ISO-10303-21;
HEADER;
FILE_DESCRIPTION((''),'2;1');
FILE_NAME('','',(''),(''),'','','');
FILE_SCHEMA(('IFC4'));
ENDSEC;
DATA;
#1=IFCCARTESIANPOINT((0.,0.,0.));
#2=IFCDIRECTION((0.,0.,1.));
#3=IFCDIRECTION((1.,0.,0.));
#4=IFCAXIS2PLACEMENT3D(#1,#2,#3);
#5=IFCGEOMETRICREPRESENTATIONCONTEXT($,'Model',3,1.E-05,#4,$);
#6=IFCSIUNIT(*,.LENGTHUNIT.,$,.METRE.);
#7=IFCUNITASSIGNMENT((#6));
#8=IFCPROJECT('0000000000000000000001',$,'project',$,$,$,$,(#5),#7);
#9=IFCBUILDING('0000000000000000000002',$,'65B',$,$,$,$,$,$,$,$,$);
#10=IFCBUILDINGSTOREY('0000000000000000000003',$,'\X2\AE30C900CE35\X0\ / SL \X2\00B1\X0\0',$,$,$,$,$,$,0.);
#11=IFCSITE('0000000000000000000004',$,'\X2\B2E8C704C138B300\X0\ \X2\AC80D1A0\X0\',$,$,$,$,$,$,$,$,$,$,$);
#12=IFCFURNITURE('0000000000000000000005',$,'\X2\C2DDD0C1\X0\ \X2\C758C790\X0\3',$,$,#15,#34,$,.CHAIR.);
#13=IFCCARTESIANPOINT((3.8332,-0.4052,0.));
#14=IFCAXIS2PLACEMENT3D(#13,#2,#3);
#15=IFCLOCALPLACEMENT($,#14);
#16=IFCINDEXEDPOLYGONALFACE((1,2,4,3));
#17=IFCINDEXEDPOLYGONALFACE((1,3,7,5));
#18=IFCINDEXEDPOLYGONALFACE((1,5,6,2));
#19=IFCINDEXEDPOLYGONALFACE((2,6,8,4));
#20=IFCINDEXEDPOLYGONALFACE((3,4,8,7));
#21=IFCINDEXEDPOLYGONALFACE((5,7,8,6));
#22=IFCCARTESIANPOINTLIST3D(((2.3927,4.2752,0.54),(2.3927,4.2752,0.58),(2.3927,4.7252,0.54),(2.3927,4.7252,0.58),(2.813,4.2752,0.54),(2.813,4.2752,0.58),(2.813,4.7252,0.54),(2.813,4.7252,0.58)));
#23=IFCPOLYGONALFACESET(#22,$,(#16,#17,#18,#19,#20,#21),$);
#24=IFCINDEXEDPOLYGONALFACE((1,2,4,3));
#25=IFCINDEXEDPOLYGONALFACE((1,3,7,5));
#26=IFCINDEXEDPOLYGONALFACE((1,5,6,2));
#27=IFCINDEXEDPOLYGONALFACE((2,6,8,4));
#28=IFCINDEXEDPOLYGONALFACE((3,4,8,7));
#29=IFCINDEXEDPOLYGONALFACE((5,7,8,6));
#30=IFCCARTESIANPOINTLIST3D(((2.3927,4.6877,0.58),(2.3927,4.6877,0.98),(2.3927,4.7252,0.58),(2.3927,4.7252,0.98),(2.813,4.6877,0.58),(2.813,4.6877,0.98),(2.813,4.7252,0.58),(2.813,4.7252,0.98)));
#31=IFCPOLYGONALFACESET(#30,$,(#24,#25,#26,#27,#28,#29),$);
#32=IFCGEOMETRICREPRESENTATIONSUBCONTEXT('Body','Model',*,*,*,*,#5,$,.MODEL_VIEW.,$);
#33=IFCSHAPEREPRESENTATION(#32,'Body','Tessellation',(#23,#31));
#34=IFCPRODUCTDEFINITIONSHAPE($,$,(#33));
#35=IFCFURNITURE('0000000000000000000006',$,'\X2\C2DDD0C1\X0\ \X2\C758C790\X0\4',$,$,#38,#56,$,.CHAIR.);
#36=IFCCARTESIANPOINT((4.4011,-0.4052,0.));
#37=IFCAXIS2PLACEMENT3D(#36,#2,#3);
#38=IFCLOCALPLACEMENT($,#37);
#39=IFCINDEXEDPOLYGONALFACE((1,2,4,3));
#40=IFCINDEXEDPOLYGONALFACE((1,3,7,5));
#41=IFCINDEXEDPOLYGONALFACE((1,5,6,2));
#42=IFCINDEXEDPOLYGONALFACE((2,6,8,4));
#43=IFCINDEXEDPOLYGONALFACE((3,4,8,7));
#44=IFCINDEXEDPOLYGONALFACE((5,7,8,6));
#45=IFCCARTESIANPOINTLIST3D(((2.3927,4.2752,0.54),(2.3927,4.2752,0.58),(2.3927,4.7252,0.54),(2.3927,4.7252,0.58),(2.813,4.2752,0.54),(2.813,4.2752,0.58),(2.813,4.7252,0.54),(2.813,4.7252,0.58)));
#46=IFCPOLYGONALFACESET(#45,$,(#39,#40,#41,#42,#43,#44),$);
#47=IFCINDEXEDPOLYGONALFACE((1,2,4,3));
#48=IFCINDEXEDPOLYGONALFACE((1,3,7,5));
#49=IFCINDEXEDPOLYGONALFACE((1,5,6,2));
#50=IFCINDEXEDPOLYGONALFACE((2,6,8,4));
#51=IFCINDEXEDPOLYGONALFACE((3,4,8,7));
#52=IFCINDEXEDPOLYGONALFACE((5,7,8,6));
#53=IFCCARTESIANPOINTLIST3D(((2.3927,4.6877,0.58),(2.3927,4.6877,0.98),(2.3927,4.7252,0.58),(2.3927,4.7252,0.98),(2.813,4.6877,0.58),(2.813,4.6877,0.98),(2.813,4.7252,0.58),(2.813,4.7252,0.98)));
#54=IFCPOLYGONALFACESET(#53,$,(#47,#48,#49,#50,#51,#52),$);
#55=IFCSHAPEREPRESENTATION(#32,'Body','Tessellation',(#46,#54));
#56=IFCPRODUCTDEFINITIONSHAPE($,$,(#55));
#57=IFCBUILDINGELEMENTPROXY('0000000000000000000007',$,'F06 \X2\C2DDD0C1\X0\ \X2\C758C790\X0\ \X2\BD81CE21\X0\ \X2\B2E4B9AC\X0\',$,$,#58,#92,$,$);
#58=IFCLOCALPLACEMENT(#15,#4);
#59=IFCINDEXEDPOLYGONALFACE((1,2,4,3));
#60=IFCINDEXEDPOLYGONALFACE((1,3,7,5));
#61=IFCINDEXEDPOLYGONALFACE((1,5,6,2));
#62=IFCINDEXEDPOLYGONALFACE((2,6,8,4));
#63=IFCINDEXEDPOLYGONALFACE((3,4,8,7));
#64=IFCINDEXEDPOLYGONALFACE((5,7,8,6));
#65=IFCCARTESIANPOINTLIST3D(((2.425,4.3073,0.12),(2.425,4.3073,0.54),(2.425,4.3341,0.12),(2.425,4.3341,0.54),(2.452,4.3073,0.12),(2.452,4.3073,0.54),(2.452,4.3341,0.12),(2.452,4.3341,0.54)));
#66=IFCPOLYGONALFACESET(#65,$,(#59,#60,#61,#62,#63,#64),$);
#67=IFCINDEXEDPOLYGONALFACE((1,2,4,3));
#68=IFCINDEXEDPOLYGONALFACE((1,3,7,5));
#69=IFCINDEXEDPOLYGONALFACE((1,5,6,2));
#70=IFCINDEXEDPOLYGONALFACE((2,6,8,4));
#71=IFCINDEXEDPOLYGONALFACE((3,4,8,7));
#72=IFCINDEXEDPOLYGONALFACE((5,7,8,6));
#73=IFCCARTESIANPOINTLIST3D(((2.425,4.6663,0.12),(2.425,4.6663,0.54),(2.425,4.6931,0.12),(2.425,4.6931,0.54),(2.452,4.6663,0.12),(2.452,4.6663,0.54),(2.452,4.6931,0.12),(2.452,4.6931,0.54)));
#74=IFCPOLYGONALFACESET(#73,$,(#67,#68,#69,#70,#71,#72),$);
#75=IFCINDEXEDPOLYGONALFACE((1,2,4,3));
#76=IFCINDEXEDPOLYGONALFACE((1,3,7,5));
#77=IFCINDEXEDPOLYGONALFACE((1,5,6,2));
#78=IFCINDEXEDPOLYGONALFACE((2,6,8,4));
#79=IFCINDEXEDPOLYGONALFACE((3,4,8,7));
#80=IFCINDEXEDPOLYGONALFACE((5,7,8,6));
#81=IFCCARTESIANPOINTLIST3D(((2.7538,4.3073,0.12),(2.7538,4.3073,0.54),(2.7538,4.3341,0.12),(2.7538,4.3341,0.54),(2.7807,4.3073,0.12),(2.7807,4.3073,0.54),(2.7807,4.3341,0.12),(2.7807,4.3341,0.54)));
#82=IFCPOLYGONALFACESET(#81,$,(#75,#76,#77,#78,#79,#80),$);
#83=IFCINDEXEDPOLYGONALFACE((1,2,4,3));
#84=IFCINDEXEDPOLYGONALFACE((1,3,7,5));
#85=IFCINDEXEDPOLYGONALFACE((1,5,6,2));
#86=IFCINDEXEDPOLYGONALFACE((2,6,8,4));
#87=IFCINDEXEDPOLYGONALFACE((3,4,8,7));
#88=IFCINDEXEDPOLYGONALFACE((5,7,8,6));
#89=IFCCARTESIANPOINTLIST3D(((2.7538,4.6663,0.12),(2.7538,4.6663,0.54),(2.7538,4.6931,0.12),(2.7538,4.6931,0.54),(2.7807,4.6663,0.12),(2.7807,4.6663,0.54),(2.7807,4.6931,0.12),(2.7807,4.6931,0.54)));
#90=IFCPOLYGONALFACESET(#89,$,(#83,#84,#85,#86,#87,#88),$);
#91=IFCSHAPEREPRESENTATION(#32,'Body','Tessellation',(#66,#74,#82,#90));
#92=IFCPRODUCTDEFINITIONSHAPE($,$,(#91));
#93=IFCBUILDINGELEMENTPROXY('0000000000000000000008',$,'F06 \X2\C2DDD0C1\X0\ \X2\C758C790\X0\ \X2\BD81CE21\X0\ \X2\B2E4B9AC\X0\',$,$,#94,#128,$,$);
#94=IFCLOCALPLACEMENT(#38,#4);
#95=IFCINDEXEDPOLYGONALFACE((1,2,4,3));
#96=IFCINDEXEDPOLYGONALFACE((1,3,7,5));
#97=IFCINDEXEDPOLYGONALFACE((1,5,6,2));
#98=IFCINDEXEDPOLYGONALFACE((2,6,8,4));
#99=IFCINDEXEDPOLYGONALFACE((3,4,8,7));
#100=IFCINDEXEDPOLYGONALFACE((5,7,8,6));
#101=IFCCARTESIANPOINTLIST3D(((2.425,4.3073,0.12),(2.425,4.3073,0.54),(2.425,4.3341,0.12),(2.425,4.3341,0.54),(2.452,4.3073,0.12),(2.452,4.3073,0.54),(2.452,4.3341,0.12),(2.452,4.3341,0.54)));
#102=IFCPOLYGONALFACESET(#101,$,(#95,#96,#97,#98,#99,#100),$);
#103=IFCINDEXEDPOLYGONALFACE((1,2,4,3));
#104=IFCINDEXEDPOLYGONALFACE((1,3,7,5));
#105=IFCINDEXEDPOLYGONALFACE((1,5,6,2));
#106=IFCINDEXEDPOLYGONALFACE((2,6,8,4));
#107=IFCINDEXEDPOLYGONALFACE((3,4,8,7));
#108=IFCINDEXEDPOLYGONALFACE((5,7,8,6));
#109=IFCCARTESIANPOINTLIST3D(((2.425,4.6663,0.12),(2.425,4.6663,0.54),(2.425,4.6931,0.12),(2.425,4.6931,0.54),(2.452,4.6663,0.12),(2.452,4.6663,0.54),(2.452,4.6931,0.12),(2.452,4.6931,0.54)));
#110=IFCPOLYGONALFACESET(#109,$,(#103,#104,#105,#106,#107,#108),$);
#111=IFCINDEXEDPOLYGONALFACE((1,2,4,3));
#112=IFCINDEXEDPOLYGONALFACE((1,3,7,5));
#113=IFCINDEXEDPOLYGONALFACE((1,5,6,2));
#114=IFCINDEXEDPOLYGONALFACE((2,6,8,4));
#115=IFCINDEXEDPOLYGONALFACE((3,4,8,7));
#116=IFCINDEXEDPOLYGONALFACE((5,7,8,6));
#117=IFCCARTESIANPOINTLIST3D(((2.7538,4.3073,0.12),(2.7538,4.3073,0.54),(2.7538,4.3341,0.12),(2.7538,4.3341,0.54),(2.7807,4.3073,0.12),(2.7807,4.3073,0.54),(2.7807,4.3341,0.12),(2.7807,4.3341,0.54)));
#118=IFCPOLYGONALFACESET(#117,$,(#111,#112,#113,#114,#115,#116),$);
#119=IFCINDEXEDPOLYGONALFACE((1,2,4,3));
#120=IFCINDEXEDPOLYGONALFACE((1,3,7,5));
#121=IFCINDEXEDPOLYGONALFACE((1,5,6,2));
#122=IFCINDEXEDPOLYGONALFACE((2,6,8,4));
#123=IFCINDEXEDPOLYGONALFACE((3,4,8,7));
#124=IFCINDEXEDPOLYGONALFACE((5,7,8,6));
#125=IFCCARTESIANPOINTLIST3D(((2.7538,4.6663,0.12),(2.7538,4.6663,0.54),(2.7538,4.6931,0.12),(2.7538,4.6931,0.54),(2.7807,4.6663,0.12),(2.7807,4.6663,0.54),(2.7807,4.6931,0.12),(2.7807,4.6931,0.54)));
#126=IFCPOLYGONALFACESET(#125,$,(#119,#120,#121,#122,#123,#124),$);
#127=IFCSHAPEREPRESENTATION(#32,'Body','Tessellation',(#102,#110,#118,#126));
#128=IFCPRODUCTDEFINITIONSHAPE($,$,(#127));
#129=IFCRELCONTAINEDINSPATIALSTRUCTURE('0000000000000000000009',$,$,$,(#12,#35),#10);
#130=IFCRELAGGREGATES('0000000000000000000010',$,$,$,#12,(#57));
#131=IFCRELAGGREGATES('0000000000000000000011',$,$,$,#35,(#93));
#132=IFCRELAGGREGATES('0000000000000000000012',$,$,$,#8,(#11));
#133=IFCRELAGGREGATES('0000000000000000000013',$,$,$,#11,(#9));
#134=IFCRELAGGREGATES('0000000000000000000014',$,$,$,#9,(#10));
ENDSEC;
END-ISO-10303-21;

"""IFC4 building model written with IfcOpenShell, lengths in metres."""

from ifc_helpers import new_model, si_unit, frame, origin_with_axes, place, context, subcontext, project, spatial, polyline, outline, extrude, element, aggregate, save


model = new_model("IFC4")

# Units and contexts
model_context = context("Model", 3, precision=1e-05, world=origin_with_axes())
body_context = subcontext(model_context, "Body", "Model", "MODEL_VIEW")
ifc_project = project(units=[si_unit("LENGTHUNIT", "METRE")], contexts=[model_context])

# Site, building, storey
site = spatial("IfcSite", under=ifc_project, Name="단위세대 검토")
building = spatial("IfcBuilding", under=site, Name="65B")
storey = spatial("IfcBuildingStorey", under=building, Name="기준층 / SL ±0", Elevation=0.0)

# Furniture
furniture_1_placement = place(None, frame((3.8332, -0.4052, 0.0), z_axis=(0.0, 0.0, 1.0), x_axis=(1.0, 0.0, 0.0)))
furniture_1 = element("IfcFurniture", 1, at=furniture_1_placement, inside=storey, Name="식탁 의자3", PredefinedType="CHAIR", context=body_context, shape_type="SweptSolid", body=[
    extrude(outline(polyline([(2.813, 4.2752), (2.813, 4.7252), (2.3927, 4.7252), (2.3927, 4.2752), (2.813, 4.2752)])), frame((0.0, 0.0, 0.54)), (0.0, 0.0, 1.0), 0.04),
    extrude(outline(polyline([(2.813, 4.6877), (2.813, 4.7252), (2.3927, 4.7252), (2.3927, 4.6877), (2.813, 4.6877)])), frame((0.0, 0.0, 0.58)), (0.0, 0.0, 1.0), 0.4),
])
furniture_2_placement = place(None, frame((4.4011, -0.4052, 0.0), z_axis=(0.0, 0.0, 1.0), x_axis=(1.0, 0.0, 0.0)))
furniture_2 = element("IfcFurniture", 2, at=furniture_2_placement, inside=storey, Name="식탁 의자4", PredefinedType="CHAIR", context=body_context, shape_type="SweptSolid", body=[
    extrude(outline(polyline([(2.813, 4.2752), (2.813, 4.7252), (2.3927, 4.7252), (2.3927, 4.2752), (2.813, 4.2752)])), frame((0.0, 0.0, 0.54)), (0.0, 0.0, 1.0), 0.04),
    extrude(outline(polyline([(2.813, 4.6877), (2.813, 4.7252), (2.3927, 4.7252), (2.3927, 4.6877), (2.813, 4.6877)])), frame((0.0, 0.0, 0.58)), (0.0, 0.0, 1.0), 0.4),
])

# Building element proxies
proxy_1_placement = place(furniture_1_placement, origin_with_axes())
proxy_1 = element("IfcBuildingElementProxy", 3, at=proxy_1_placement, Name="F06 식탁 의자 북측 다리", context=body_context, shape_type="SweptSolid", body=[
    extrude(outline(polyline([(2.452, 4.3073), (2.452, 4.3341), (2.425, 4.3341), (2.425, 4.3073), (2.452, 4.3073)])), frame((0.0, 0.0, 0.12)), (0.0, 0.0, 1.0), 0.42),
    extrude(outline(polyline([(2.452, 4.6663), (2.452, 4.6931), (2.425, 4.6931), (2.425, 4.6663), (2.452, 4.6663)])), frame((0.0, 0.0, 0.12)), (0.0, 0.0, 1.0), 0.42),
    extrude(outline(polyline([(2.7807, 4.3073), (2.7807, 4.3341), (2.7538, 4.3341), (2.7538, 4.3073), (2.7807, 4.3073)])), frame((0.0, 0.0, 0.12)), (0.0, 0.0, 1.0), 0.42),
    extrude(outline(polyline([(2.7807, 4.6663), (2.7807, 4.6931), (2.7538, 4.6931), (2.7538, 4.6663), (2.7807, 4.6663)])), frame((0.0, 0.0, 0.12)), (0.0, 0.0, 1.0), 0.42),
])
aggregate(furniture_1, [proxy_1])
proxy_2_placement = place(furniture_2_placement, origin_with_axes())
proxy_2 = element("IfcBuildingElementProxy", 4, at=proxy_2_placement, Name="F06 식탁 의자 북측 다리", context=body_context, shape_type="SweptSolid", body=[
    extrude(outline(polyline([(2.452, 4.3073), (2.452, 4.3341), (2.425, 4.3341), (2.425, 4.3073), (2.452, 4.3073)])), frame((0.0, 0.0, 0.12)), (0.0, 0.0, 1.0), 0.42),
    extrude(outline(polyline([(2.452, 4.6663), (2.452, 4.6931), (2.425, 4.6931), (2.425, 4.6663), (2.452, 4.6663)])), frame((0.0, 0.0, 0.12)), (0.0, 0.0, 1.0), 0.42),
    extrude(outline(polyline([(2.7807, 4.3073), (2.7807, 4.3341), (2.7538, 4.3341), (2.7538, 4.3073), (2.7807, 4.3073)])), frame((0.0, 0.0, 0.12)), (0.0, 0.0, 1.0), 0.42),
    extrude(outline(polyline([(2.7807, 4.6663), (2.7807, 4.6931), (2.7538, 4.6931), (2.7538, 4.6663), (2.7807, 4.6663)])), frame((0.0, 0.0, 0.12)), (0.0, 0.0, 1.0), 0.42),
])
aggregate(furniture_2, [proxy_2])

save(model, "model.ifc")
